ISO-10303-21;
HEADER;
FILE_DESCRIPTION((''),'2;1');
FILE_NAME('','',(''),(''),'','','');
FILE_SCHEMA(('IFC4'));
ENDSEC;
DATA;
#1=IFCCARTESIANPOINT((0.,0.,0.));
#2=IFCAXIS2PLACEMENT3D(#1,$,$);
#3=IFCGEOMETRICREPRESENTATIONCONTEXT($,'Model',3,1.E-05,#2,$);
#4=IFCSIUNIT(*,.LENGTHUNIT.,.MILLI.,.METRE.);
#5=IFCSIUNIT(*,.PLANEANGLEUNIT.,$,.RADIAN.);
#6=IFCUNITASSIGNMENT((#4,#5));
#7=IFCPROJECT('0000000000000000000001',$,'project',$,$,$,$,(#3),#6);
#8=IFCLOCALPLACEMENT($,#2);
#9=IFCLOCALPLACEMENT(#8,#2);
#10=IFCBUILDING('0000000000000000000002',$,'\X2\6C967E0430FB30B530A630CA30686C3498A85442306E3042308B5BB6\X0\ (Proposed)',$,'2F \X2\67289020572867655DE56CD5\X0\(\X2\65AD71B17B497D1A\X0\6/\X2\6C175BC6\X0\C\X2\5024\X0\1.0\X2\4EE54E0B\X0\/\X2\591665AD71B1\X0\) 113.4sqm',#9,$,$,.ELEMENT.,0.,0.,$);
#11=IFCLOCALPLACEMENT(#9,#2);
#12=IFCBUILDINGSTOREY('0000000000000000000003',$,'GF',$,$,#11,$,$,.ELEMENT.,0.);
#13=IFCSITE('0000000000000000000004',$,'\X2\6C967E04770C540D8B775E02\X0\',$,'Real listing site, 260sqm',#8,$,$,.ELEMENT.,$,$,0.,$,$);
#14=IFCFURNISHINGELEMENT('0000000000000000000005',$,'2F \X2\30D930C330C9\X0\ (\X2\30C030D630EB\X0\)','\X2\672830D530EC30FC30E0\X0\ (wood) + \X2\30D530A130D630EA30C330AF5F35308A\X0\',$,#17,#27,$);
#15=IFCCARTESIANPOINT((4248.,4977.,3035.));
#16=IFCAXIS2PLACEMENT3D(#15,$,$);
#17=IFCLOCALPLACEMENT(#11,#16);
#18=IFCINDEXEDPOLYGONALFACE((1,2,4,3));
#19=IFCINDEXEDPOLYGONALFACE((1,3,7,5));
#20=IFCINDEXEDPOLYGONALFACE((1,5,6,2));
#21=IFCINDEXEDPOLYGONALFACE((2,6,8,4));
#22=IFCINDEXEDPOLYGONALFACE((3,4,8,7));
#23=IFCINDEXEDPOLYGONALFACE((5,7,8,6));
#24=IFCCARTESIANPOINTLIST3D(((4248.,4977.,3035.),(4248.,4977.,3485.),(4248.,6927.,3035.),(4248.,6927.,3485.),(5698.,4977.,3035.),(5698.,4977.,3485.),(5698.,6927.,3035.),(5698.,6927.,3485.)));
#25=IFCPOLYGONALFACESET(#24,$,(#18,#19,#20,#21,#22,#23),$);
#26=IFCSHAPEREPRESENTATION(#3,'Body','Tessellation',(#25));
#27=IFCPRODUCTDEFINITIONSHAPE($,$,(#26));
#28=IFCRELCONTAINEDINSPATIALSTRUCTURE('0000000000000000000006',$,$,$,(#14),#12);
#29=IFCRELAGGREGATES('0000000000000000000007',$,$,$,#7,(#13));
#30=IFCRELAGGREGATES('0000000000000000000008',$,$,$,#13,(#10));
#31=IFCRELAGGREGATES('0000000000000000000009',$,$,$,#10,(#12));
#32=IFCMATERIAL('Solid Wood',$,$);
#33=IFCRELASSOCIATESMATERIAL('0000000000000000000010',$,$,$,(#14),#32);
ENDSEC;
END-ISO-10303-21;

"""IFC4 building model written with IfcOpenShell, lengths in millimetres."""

from ifc_helpers import new_model, si_unit, frame, frame_2d, origin, place, context, project, spatial, rectangle, extrude, material, element, save


model = new_model("IFC4")

# Units and contexts
model_context = context("Model", 3, precision=1e-05, world=origin())
ifc_project = project(units=[si_unit("LENGTHUNIT", "METRE", prefix="MILLI"), si_unit("PLANEANGLEUNIT", "RADIAN")], contexts=[model_context])

# Site, building, storey
site_placement = place(None, origin())
site = spatial("IfcSite", under=ifc_project, at=site_placement, Name="沖縄県名護市", ObjectType="Real listing site, 260sqm", CompositionType="ELEMENT", RefElevation=0.0)
building_placement = place(site_placement, origin())
building = spatial("IfcBuilding", under=site, at=building_placement, Name="沖縄・サウナと水風呂のある家 (Proposed)", ObjectType="2F 木造在来工法(断熱等級6/気密C値1.0以下/外断熱) 113.4sqm", CompositionType="ELEMENT", ElevationOfRefHeight=0.0, ElevationOfTerrain=0.0)
storey_placement = place(building_placement, origin())
storey = spatial("IfcBuildingStorey", under=building, at=storey_placement, Name="GF", CompositionType="ELEMENT", Elevation=0.0)

# Shared definitions
ifc_material_1 = material(Name="Solid Wood")

# Furnishing element
furnishing_1_placement = place(storey_placement, frame((4248.0, 4977.0, 3035.0)))
element("IfcFurnishingElement", 1, at=furnishing_1_placement, inside=storey, material=ifc_material_1, Name="2F ベッド (ダブル)", Description="木フレーム (wood) + ファブリック張り", context=model_context, shape_type="SweptSolid", body=[
    extrude(rectangle(XDim=1450.0, YDim=1950.0, at=frame_2d((725.0, 975.0))), frame((4248.0, 4977.0, 3035.0)), (0.0, 0.0, 1.0), 450.0),
])

save(model, "model.ifc")
